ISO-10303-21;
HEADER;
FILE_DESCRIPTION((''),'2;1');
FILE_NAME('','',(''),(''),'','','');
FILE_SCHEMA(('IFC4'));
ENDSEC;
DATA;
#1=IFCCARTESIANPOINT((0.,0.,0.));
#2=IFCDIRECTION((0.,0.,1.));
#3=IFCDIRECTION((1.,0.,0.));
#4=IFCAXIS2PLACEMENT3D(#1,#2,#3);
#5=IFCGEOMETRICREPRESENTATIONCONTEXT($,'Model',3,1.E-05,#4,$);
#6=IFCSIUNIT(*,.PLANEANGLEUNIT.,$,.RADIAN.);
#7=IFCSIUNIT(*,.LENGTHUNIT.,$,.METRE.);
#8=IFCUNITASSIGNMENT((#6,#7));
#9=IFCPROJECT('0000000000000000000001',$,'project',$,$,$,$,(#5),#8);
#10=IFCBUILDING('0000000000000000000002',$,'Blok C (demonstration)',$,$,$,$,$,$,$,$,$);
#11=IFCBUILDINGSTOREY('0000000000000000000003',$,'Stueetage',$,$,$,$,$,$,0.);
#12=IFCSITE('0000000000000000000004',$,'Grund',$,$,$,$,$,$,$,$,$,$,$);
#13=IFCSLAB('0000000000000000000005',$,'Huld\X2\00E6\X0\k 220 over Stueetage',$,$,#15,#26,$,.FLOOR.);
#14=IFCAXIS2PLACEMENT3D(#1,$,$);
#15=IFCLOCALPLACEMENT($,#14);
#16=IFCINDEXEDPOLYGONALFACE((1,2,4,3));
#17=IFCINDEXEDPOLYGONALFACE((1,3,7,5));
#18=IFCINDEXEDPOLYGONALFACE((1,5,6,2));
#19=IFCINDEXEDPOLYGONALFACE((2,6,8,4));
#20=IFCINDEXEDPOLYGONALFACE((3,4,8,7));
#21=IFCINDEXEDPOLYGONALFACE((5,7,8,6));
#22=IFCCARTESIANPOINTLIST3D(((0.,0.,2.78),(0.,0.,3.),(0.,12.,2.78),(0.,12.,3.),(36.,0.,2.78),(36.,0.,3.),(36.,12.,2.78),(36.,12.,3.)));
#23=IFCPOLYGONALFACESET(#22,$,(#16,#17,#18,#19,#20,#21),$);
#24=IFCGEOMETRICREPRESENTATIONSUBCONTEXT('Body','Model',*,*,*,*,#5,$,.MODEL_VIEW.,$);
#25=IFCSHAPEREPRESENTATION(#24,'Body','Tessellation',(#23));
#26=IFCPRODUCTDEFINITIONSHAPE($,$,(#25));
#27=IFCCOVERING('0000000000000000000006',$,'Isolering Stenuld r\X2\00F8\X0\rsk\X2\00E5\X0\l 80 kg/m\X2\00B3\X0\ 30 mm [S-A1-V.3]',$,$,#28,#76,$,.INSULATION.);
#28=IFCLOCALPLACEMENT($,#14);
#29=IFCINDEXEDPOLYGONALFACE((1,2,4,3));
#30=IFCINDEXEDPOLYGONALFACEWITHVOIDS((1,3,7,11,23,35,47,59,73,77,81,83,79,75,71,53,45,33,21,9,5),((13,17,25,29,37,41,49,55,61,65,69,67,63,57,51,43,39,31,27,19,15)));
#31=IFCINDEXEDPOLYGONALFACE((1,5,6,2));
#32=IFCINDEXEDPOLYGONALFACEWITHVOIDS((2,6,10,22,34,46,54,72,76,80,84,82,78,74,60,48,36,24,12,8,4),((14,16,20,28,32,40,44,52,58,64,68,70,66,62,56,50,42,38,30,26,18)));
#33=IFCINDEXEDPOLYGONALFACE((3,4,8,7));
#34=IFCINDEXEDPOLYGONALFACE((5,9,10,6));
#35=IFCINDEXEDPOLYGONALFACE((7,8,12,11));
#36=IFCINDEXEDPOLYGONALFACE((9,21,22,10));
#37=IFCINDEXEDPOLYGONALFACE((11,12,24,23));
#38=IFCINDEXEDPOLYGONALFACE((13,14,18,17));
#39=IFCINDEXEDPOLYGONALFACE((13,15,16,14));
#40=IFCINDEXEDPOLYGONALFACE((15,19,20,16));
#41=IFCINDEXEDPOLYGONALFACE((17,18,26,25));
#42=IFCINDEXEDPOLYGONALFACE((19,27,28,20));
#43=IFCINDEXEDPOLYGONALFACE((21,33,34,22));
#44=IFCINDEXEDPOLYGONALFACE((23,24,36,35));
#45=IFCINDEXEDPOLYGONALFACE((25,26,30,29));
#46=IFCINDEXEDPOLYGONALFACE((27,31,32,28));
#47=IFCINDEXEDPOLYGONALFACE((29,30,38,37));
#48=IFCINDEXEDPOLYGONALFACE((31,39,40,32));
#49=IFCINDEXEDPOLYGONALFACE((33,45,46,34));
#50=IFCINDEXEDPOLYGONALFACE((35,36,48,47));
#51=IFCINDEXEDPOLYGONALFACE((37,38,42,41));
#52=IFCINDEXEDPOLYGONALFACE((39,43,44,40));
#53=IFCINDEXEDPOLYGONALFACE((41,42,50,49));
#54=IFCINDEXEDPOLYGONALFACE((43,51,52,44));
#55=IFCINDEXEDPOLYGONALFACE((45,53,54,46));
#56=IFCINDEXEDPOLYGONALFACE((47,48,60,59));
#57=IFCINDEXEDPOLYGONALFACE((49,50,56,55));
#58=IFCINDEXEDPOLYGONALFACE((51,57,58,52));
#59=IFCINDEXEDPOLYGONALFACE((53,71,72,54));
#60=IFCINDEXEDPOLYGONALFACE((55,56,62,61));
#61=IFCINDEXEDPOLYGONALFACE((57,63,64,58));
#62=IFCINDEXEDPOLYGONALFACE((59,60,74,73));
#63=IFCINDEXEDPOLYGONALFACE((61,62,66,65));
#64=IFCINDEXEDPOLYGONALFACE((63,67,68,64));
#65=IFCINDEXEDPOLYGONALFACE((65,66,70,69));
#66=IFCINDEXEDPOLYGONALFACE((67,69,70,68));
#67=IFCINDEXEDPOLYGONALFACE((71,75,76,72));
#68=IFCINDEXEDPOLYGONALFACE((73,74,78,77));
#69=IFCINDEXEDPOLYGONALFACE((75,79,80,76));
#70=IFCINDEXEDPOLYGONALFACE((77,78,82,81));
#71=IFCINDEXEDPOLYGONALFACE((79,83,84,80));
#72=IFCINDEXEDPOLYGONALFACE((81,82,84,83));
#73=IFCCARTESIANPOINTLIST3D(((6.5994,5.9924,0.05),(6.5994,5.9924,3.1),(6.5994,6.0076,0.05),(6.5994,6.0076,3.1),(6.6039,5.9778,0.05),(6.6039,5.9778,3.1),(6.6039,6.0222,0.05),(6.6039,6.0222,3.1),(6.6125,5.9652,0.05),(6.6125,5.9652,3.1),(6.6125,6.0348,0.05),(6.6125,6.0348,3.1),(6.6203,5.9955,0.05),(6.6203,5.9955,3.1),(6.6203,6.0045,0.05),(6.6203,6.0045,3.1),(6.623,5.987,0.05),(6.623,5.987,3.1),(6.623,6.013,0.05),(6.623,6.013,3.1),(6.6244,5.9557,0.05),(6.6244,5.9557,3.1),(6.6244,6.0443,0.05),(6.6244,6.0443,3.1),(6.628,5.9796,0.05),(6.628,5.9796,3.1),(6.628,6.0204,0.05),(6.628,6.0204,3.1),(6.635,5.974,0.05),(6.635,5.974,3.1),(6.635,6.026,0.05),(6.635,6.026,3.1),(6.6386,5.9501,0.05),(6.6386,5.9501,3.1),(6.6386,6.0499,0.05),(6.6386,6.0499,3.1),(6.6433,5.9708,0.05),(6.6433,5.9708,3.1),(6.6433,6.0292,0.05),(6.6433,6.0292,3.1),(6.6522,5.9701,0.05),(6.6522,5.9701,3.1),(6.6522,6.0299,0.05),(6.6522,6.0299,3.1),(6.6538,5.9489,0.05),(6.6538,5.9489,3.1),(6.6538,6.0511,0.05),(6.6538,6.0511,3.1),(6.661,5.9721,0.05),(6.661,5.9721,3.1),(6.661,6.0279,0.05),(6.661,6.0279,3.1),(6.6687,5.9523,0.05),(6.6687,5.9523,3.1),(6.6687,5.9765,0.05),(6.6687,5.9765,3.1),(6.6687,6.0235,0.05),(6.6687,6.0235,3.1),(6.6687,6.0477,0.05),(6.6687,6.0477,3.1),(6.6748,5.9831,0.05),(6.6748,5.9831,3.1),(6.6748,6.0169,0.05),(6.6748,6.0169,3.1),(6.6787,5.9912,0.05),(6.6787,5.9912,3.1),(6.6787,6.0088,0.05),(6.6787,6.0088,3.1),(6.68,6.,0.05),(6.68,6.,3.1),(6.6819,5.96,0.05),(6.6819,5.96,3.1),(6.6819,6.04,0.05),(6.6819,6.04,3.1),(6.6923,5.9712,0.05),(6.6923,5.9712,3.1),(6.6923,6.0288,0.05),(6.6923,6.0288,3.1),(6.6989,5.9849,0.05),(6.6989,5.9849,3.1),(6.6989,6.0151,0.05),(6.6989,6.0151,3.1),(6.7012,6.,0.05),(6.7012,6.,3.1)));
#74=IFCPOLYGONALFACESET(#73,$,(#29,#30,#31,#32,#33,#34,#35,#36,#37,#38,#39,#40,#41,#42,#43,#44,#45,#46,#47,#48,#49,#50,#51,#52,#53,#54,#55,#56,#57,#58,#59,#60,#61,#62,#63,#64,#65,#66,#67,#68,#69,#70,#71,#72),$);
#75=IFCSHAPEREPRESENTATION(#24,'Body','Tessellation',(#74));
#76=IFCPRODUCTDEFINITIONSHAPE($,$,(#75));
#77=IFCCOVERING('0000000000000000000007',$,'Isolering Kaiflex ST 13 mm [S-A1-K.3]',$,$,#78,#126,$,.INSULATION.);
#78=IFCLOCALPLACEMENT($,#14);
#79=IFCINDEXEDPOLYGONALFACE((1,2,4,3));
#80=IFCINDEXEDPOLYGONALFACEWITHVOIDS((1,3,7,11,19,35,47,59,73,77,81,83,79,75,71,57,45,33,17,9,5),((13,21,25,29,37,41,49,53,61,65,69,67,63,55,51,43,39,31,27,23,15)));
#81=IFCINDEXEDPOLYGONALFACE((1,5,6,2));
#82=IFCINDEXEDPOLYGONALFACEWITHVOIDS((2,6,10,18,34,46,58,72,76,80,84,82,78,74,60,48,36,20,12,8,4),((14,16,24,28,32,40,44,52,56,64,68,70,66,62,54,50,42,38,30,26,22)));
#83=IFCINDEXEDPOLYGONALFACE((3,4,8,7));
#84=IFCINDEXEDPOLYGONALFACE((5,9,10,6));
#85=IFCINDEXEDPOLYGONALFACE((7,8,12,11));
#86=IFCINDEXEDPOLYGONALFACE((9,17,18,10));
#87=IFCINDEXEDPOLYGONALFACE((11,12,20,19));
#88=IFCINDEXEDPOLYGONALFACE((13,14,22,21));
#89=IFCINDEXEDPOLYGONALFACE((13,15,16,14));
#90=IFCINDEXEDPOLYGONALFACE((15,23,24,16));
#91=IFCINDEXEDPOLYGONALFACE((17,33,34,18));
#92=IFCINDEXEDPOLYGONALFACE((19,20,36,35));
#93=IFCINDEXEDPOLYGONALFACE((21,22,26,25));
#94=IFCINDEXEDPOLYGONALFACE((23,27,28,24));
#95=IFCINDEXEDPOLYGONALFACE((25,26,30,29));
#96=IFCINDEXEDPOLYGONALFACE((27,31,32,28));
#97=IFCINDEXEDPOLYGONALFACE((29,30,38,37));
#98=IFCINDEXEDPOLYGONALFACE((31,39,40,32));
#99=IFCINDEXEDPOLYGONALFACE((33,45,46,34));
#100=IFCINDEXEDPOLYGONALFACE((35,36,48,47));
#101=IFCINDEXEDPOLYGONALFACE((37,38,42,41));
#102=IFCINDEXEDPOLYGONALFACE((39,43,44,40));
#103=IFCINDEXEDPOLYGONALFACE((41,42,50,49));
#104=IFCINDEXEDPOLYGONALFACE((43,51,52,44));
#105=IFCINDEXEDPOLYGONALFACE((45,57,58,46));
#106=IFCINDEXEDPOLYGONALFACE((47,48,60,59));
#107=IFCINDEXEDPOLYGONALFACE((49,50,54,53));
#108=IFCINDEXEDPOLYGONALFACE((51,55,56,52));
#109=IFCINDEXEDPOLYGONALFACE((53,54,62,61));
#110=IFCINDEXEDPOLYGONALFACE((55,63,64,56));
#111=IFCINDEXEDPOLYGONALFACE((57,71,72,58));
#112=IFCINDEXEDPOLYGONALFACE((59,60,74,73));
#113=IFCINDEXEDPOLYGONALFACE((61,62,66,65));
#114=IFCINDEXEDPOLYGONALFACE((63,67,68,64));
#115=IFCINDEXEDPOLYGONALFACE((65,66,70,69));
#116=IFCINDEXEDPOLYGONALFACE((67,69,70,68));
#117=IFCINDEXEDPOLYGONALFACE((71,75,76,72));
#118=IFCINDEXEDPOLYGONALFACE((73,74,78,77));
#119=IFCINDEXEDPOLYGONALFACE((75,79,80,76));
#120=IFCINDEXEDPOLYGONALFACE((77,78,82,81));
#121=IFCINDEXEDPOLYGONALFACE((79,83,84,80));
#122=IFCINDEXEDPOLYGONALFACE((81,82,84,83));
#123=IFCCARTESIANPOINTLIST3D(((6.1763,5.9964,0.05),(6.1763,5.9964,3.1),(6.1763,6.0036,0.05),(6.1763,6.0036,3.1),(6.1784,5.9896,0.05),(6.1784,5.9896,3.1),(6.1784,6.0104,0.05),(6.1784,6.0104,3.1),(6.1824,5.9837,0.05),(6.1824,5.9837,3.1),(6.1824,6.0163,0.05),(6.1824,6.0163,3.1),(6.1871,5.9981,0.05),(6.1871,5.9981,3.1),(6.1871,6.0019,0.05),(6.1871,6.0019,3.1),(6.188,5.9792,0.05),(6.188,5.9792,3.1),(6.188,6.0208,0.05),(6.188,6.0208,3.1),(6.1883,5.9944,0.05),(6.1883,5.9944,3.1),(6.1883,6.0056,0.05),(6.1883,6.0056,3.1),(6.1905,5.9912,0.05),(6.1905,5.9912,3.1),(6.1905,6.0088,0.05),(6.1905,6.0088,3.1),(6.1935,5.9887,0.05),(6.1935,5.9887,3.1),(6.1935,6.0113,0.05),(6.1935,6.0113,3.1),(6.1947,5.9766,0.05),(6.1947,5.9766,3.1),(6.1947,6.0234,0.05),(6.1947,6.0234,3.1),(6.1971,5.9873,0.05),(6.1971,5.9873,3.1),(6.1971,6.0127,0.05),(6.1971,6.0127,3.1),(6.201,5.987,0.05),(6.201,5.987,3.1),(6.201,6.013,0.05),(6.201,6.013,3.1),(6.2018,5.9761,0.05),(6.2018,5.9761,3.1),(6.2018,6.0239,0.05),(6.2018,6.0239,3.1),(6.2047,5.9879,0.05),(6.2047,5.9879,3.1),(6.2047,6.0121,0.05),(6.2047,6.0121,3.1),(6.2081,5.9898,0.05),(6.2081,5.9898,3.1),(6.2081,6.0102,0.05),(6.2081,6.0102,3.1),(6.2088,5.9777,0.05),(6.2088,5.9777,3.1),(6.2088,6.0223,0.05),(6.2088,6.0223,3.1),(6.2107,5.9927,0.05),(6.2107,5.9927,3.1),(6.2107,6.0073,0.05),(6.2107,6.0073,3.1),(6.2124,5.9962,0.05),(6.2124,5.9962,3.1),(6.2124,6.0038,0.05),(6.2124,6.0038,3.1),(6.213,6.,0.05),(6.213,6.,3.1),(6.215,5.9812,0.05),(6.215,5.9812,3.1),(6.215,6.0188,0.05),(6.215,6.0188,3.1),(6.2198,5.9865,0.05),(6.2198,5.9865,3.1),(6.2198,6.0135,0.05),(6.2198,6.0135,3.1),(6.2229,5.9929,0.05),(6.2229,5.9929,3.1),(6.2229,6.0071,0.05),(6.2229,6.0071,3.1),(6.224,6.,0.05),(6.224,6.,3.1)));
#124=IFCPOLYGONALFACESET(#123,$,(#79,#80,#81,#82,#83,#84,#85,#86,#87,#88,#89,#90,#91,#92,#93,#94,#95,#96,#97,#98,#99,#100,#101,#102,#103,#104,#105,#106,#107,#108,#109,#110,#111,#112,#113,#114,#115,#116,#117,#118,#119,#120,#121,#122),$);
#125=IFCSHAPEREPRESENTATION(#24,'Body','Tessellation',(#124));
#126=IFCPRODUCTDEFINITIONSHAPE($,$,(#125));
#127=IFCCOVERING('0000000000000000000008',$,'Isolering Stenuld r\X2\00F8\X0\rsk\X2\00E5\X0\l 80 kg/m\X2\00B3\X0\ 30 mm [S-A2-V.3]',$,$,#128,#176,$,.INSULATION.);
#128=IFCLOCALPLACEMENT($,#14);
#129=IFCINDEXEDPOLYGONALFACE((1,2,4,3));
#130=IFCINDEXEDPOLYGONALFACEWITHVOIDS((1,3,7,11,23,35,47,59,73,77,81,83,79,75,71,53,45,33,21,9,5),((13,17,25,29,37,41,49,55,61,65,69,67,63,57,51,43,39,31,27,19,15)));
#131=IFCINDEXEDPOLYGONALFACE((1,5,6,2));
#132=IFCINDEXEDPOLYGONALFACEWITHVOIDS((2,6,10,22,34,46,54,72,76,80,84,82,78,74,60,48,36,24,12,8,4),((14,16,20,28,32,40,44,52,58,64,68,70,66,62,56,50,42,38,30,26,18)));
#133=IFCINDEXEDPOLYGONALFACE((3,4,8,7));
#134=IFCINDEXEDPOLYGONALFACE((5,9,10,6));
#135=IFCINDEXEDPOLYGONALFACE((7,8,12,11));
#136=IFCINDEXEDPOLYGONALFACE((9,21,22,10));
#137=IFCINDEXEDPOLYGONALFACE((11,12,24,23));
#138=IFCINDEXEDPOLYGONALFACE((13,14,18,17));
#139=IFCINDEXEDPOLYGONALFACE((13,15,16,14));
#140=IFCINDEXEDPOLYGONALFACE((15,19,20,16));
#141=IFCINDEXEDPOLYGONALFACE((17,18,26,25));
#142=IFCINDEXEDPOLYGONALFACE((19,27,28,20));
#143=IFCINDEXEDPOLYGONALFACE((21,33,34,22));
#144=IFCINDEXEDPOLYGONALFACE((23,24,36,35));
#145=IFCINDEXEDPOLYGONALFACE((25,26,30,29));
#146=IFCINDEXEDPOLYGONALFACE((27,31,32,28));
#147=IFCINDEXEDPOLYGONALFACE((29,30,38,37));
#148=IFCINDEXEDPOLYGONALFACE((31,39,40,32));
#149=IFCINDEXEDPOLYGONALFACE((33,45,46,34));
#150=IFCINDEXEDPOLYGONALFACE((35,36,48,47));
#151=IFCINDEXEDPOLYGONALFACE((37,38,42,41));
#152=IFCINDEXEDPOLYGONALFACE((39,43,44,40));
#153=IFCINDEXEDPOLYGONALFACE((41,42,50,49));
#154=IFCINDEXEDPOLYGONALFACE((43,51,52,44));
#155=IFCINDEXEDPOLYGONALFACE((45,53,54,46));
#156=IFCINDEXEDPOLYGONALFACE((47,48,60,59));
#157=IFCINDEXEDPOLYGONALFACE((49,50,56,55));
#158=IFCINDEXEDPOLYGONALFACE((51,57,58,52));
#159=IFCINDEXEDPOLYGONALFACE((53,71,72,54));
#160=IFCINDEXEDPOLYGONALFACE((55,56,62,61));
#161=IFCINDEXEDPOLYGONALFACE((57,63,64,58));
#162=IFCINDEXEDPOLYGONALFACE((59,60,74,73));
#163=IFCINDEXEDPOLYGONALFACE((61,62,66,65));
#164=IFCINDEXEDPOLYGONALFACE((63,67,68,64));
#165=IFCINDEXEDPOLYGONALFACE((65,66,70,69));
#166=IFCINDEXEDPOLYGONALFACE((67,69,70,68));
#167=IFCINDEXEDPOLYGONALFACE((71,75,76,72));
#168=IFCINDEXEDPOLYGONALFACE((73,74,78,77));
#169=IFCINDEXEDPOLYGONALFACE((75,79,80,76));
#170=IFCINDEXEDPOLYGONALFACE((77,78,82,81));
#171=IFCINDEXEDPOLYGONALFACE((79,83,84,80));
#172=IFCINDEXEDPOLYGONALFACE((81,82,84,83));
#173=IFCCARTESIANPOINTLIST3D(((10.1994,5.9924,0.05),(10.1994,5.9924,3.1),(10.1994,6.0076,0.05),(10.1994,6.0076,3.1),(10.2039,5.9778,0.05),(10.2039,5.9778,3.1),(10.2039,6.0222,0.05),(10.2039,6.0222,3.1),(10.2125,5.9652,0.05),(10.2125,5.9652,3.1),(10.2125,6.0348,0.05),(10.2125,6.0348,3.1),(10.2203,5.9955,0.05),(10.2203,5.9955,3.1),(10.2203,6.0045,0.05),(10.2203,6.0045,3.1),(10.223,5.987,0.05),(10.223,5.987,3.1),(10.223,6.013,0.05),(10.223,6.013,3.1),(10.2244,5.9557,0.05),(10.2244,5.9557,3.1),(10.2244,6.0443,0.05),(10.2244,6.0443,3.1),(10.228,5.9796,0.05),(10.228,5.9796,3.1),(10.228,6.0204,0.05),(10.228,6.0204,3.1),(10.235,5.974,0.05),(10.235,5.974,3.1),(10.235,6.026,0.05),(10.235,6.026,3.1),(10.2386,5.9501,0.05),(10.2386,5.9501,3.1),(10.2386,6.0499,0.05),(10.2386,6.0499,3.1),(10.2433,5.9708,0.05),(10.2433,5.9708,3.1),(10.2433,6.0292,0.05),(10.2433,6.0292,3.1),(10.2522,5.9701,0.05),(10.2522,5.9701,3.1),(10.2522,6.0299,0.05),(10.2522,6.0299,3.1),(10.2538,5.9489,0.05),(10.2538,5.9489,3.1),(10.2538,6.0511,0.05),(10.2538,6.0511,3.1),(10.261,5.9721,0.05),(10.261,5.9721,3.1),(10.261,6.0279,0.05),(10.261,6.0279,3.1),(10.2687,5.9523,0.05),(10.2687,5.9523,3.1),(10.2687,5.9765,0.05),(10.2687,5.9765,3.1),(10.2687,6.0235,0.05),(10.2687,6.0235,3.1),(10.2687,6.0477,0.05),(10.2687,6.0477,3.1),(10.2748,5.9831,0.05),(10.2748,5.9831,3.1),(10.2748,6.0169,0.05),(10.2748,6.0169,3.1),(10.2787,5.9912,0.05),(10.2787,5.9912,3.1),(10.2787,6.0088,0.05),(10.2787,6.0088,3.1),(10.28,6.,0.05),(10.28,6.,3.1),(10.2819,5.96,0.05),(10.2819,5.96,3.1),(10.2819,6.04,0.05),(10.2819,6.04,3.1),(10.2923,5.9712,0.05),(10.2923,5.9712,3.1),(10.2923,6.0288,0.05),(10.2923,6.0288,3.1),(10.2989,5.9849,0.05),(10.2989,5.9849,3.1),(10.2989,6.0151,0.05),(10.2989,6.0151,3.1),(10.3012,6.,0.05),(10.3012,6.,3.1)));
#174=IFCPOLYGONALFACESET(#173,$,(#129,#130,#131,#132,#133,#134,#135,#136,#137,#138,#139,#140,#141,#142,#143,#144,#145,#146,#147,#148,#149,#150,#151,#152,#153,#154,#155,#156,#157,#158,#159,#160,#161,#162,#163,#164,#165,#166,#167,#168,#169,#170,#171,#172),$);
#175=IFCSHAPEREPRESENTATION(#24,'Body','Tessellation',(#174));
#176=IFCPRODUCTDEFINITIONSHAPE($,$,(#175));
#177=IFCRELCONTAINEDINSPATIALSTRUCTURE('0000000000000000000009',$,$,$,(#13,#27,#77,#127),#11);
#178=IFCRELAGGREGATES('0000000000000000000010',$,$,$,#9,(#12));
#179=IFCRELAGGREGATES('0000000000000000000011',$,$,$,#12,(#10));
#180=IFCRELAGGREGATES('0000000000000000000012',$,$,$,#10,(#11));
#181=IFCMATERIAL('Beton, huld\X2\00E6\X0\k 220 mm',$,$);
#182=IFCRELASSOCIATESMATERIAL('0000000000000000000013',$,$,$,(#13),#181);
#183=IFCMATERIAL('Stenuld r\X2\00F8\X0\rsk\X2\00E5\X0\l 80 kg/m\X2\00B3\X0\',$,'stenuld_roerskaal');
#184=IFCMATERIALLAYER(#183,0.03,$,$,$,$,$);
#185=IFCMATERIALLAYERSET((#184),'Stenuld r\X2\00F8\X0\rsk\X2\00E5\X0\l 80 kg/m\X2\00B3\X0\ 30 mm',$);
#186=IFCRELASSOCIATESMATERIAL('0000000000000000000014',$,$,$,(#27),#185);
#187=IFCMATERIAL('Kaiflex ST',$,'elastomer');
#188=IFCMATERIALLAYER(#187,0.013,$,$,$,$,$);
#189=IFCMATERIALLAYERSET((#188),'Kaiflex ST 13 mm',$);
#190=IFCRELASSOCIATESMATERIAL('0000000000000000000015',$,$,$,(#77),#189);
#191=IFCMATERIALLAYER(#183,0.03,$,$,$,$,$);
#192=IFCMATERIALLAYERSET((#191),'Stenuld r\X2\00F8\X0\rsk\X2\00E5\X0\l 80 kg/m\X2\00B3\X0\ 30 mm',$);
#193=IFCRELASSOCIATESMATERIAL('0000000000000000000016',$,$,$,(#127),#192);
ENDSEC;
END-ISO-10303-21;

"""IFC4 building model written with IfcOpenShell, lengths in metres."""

from ifc_helpers import new_model, si_unit, frame, origin_with_axes, place, context, subcontext, project, spatial, polyline, hollow_circle, outline, extrude, material, layer, layer_set, element, save


model = new_model("IFC4")

# Units and contexts
model_context = context("Model", 3, precision=1e-05, world=origin_with_axes())
body_context = subcontext(model_context, "Body", "Model", "MODEL_VIEW")
ifc_project = project(units=[si_unit("PLANEANGLEUNIT", "RADIAN"), si_unit("LENGTHUNIT", "METRE")], contexts=[model_context])

# Site, building, storey
site = spatial("IfcSite", under=ifc_project, Name="Grund")
building = spatial("IfcBuilding", under=site, Name="Blok C (demonstration)")
storey = spatial("IfcBuildingStorey", under=building, Name="Stueetage", Elevation=0.0)

# Slab
ifc_material_1 = material(Name="Beton, huldæk 220 mm")
slab_placement = place(None, origin_with_axes())
element("IfcSlab", 1, at=slab_placement, inside=storey, material=ifc_material_1, Name="Huldæk 220 over Stueetage", PredefinedType="FLOOR", context=body_context, shape_type="SweptSolid", body=[
    extrude(outline(polyline([(0.0, 0.0), (36.0, 0.0), (36.0, 12.0), (0.0, 12.0), (0.0, 0.0)])), frame((0.0, 0.0, 2.78)), (0.0, 0.0, 1.0), 0.22),
])

# Coverings
ifc_material_2 = material(Name="Stenuld rørskål 80 kg/m³", Category="stenuld_roerskaal")
ifc_layer_1 = layer(ifc_material_2, 0.03)
ifc_layer_set_1 = layer_set([ifc_layer_1], Name="Stenuld rørskål 80 kg/m³ 30 mm")
covering_1_placement = place(None, origin_with_axes())
element("IfcCovering", 2, at=covering_1_placement, inside=storey, material=ifc_layer_set_1, Name="Isolering Stenuld rørskål 80 kg/m³ 30 mm [S-A1-V.3]", PredefinedType="INSULATION", context=body_context, shape_type="SweptSolid", body=[
    extrude(hollow_circle(Radius=0.0512, WallThickness=0.0212), frame((6.65, 6.0, 0.05), z_axis=(0.0, 0.0, 1.0), x_axis=(1.0, 0.0, 0.0)), (0.0, 0.0, 1.0), 3.05),
])
ifc_material_3 = material(Name="Kaiflex ST", Category="elastomer")
ifc_layer_2 = layer(ifc_material_3, 0.013)
ifc_layer_set_2 = layer_set([ifc_layer_2], Name="Kaiflex ST 13 mm")
covering_2_placement = place(None, origin_with_axes())
element("IfcCovering", 3, at=covering_2_placement, inside=storey, material=ifc_layer_set_2, Name="Isolering Kaiflex ST 13 mm [S-A1-K.3]", PredefinedType="INSULATION", context=body_context, shape_type="SweptSolid", body=[
    extrude(hollow_circle(Radius=0.024, WallThickness=0.011), frame((6.2, 6.0, 0.05), z_axis=(0.0, 0.0, 1.0), x_axis=(1.0, 0.0, 0.0)), (0.0, 0.0, 1.0), 3.05),
])
ifc_layer_3 = layer(ifc_material_2, 0.03)
ifc_layer_set_3 = layer_set([ifc_layer_3], Name="Stenuld rørskål 80 kg/m³ 30 mm")
covering_3_placement = place(None, origin_with_axes())
element("IfcCovering", 4, at=covering_3_placement, inside=storey, material=ifc_layer_set_3, Name="Isolering Stenuld rørskål 80 kg/m³ 30 mm [S-A2-V.3]", PredefinedType="INSULATION", context=body_context, shape_type="SweptSolid", body=[
    extrude(hollow_circle(Radius=0.0512, WallThickness=0.0212), frame((10.25, 6.0, 0.05), z_axis=(0.0, 0.0, 1.0), x_axis=(1.0, 0.0, 0.0)), (0.0, 0.0, 1.0), 3.05),
])

save(model, "model.ifc")
